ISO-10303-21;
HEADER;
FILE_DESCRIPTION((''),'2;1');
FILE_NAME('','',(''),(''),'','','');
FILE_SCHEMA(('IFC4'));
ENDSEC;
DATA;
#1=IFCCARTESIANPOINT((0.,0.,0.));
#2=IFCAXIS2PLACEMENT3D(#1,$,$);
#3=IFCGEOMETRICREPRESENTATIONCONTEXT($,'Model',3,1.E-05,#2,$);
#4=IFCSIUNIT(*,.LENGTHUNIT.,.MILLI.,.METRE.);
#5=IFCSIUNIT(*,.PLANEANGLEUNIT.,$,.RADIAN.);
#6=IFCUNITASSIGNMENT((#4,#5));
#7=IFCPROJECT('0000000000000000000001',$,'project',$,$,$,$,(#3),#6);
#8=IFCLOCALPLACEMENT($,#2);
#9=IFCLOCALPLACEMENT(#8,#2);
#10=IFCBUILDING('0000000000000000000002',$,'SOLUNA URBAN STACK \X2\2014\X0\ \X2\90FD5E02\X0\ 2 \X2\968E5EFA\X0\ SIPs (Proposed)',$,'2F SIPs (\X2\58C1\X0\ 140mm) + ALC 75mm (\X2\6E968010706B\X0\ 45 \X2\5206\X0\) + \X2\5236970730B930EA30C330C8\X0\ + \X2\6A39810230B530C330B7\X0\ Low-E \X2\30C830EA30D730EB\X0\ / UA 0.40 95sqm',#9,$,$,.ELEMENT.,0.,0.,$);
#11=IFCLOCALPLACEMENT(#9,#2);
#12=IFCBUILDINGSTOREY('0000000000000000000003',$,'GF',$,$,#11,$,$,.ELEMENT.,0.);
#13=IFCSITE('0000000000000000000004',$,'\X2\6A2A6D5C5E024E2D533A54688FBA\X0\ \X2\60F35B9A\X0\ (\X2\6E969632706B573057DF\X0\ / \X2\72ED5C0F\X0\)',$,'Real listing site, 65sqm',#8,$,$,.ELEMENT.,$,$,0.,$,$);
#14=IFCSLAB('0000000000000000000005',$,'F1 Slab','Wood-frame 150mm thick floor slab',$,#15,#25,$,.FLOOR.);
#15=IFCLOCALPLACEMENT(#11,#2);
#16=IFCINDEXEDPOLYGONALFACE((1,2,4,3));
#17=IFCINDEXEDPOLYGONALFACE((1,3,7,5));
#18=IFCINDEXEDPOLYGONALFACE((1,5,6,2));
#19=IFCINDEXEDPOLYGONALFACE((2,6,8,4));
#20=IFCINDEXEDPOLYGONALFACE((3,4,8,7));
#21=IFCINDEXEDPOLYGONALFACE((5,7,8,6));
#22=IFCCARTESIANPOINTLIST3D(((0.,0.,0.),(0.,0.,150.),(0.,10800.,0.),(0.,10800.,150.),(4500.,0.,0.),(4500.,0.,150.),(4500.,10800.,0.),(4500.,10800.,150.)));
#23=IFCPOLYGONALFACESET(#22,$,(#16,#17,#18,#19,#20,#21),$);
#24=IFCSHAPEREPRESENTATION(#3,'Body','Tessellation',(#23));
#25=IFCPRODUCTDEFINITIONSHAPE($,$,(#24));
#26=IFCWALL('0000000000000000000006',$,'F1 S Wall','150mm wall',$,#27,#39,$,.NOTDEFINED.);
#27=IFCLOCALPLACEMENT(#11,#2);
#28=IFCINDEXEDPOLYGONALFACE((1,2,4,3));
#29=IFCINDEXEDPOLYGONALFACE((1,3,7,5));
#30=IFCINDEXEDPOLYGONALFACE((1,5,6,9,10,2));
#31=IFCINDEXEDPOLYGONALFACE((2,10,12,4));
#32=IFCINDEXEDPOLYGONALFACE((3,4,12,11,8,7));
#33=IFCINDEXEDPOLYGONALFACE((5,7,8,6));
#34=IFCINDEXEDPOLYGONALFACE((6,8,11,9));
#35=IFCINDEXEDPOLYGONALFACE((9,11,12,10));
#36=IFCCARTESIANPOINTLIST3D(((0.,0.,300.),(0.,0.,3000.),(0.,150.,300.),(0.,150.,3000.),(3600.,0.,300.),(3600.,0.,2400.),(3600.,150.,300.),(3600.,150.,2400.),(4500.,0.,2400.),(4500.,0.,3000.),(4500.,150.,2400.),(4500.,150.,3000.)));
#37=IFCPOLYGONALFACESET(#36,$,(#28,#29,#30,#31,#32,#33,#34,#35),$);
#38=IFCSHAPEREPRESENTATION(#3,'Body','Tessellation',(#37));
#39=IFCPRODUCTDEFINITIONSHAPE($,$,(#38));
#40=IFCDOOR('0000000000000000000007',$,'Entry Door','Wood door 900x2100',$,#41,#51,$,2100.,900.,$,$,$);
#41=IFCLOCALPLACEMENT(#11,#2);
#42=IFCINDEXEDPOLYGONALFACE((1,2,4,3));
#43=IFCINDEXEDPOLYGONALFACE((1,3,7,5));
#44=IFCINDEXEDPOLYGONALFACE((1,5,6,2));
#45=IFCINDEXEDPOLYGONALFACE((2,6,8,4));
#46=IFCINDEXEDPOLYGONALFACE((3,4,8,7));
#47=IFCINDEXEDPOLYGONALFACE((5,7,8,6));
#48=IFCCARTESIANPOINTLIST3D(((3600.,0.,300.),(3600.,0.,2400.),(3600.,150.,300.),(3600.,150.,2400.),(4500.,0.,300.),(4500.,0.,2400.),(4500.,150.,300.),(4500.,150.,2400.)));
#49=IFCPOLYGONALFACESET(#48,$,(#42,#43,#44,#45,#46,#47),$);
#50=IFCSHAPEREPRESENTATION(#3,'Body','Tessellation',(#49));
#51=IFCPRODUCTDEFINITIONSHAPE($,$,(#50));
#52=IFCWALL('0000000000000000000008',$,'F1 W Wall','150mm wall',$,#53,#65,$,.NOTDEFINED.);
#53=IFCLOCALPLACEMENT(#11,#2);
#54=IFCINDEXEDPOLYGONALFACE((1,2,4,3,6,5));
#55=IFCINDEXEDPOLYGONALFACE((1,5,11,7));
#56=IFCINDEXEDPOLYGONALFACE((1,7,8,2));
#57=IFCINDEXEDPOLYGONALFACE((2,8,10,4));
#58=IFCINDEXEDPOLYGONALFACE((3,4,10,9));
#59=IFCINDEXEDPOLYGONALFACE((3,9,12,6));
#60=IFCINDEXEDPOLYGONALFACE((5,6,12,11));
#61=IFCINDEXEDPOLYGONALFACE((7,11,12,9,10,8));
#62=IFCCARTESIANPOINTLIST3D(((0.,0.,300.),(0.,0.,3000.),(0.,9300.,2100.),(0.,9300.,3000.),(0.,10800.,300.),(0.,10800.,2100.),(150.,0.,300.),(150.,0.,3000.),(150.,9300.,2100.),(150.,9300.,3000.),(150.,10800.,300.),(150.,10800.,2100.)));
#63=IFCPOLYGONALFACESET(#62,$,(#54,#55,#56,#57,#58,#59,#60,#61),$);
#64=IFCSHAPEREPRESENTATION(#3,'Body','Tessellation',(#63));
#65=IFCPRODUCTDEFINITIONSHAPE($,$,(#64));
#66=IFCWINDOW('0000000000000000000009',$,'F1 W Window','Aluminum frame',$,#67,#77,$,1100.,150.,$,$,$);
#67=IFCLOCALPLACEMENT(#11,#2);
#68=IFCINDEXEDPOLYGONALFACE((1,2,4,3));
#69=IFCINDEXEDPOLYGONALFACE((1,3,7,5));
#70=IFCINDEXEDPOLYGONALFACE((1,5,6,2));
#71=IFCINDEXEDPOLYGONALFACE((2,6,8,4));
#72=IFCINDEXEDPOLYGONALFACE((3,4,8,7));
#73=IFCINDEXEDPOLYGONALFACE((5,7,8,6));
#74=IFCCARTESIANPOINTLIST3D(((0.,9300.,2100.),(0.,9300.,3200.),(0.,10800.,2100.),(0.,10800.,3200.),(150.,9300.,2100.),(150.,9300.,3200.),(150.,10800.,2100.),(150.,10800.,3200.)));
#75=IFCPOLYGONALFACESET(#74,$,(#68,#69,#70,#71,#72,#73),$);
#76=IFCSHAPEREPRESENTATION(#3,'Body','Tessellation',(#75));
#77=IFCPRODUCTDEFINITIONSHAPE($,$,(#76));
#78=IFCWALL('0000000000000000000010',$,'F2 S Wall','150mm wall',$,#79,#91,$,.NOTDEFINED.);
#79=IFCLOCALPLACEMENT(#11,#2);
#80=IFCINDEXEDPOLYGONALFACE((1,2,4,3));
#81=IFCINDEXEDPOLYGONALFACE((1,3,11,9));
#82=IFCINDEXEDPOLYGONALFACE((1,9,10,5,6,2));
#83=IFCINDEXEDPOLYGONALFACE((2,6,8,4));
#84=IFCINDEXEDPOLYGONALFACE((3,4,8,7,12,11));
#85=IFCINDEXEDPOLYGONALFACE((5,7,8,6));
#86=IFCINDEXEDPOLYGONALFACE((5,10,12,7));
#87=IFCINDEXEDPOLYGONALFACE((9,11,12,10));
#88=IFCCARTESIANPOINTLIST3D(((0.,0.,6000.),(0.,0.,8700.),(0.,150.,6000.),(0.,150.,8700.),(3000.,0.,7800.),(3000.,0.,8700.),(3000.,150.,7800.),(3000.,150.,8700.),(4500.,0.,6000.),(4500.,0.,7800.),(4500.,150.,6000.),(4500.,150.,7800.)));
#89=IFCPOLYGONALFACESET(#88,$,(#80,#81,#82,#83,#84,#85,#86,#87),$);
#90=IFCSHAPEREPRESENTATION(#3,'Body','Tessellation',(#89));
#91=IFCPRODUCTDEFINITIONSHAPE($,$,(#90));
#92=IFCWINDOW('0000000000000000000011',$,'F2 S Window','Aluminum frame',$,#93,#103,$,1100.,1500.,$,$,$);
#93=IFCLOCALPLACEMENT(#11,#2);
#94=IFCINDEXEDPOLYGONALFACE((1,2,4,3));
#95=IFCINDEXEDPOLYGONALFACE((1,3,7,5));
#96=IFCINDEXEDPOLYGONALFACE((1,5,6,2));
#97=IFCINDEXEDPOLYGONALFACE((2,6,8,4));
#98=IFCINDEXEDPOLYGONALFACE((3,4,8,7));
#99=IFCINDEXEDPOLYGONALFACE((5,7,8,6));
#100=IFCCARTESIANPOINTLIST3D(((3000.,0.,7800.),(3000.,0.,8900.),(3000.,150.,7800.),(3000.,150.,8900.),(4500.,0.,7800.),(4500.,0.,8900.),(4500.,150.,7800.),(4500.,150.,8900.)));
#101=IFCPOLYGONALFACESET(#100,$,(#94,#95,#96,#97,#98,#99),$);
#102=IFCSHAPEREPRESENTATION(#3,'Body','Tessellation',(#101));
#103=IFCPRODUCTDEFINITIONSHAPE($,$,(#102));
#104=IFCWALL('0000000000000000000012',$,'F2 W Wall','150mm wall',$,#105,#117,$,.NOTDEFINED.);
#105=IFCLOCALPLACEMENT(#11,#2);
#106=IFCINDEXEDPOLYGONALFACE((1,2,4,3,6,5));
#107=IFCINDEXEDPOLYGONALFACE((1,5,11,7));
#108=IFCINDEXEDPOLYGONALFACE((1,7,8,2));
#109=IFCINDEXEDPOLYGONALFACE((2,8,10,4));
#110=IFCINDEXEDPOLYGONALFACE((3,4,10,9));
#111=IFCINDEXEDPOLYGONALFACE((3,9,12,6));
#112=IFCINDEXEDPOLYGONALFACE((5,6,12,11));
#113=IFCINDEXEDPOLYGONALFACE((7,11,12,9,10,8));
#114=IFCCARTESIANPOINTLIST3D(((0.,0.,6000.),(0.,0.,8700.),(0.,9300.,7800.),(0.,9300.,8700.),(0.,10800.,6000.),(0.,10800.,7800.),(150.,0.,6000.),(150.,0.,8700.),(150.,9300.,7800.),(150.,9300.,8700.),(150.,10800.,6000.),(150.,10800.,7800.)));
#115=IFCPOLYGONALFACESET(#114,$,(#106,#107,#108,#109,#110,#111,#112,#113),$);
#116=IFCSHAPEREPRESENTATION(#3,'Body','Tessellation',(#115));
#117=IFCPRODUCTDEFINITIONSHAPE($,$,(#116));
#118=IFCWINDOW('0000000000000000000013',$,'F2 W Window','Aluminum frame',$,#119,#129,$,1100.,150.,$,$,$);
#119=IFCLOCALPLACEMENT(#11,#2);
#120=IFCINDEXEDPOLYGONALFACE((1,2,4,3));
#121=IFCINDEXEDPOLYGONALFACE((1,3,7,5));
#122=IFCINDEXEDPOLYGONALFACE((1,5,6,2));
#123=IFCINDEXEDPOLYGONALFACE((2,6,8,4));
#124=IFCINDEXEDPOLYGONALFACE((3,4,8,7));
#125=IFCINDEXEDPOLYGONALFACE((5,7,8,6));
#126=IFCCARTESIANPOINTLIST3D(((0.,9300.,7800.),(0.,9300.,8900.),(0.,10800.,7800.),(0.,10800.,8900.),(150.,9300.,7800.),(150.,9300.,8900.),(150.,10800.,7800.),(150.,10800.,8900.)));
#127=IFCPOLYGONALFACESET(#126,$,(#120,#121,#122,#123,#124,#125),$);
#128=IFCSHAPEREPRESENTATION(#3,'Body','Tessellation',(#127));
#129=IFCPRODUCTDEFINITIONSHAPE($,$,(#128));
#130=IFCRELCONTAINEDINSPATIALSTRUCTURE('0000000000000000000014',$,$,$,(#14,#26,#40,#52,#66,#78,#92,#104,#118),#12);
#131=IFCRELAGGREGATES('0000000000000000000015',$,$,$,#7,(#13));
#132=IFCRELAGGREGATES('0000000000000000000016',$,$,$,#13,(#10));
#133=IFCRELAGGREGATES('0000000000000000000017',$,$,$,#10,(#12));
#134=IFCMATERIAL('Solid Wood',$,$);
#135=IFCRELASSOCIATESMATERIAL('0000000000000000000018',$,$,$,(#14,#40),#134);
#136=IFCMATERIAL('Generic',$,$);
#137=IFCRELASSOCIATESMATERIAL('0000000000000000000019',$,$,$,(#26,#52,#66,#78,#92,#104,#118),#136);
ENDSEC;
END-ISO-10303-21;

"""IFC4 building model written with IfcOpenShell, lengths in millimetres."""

from ifc_helpers import new_model, si_unit, frame, frame_2d, origin, place, context, project, spatial, rectangle, extrude, material, element, fill, save


model = new_model("IFC4")

# Units and contexts
model_context = context("Model", 3, precision=1e-05, world=origin())
ifc_project = project(units=[si_unit("LENGTHUNIT", "METRE", prefix="MILLI"), si_unit("PLANEANGLEUNIT", "RADIAN")], contexts=[model_context])

# Site, building, storey
site_placement = place(None, origin())
site = spatial("IfcSite", under=ifc_project, at=site_placement, Name="横浜市中区周辺 想定 (準防火地域 / 狭小)", ObjectType="Real listing site, 65sqm", CompositionType="ELEMENT", RefElevation=0.0)
building_placement = place(site_placement, origin())
building = spatial("IfcBuilding", under=site, at=building_placement, Name="SOLUNA URBAN STACK — 都市 2 階建 SIPs (Proposed)", ObjectType="2F SIPs (壁 140mm) + ALC 75mm (準耐火 45 分) + 制震スリット + 樹脂サッシ Low-E トリプル / UA 0.40 95sqm", CompositionType="ELEMENT", ElevationOfRefHeight=0.0, ElevationOfTerrain=0.0)
storey_placement = place(building_placement, origin())
storey = spatial("IfcBuildingStorey", under=building, at=storey_placement, Name="GF", CompositionType="ELEMENT", Elevation=0.0)

# Slab
ifc_material_1 = material(Name="Solid Wood")
slab_1_placement = place(storey_placement, origin())
element("IfcSlab", 1, at=slab_1_placement, inside=storey, material=ifc_material_1, Name="F1 Slab", Description="Wood-frame 150mm thick floor slab", PredefinedType="FLOOR", context=model_context, shape_type="SweptSolid", body=[
    extrude(rectangle(XDim=4500.0, YDim=10800.0, at=frame_2d((2250.0, 5400.0))), origin(), (0.0, 0.0, 1.0), 150.0),
])

# Shared definitions
ifc_material_2 = material(Name="Generic")

# Wall, opening, door
wall_1_placement = place(storey_placement, frame((0.0, 0.0, 150.0)))
wall_1 = element("IfcWall", 2, at=wall_1_placement, inside=storey, material=ifc_material_2, Name="F1 S Wall", Description="150mm wall", PredefinedType="NOTDEFINED", context=model_context, shape_type="SweptSolid", body=[
    extrude(rectangle(XDim=4500.0, YDim=150.0, at=frame_2d((2250.0, 75.0))), frame((0.0, 0.0, 150.0)), (0.0, 0.0, 1.0), 2700.0),
])
opening_1_placement = place(storey_placement, frame((1800.0, 0.0, 150.0)))
opening_1 = element("IfcOpeningElement", 3, at=opening_1_placement, cuts=wall_1, PredefinedType="NOTDEFINED", context=model_context, shape_type="SweptSolid", body=[
    extrude(rectangle(XDim=900.0, YDim=150.0, at=frame_2d((450.0, 75.0))), frame((1800.0, 0.0, 150.0)), (0.0, 0.0, 1.0), 2100.0),
])
door_placement = place(storey_placement, frame((1800.0, 0.0, 150.0)))
door = element("IfcDoor", 4, at=door_placement, inside=storey, material=ifc_material_1, Name="Entry Door", Description="Wood door 900x2100", OverallHeight=2100.0, OverallWidth=900.0, context=model_context, shape_type="SweptSolid", body=[
    extrude(rectangle(XDim=900.0, YDim=150.0, at=frame_2d((450.0, 75.0))), frame((1800.0, 0.0, 150.0)), (0.0, 0.0, 1.0), 2100.0),
])
fill(opening_1, door)

# Walls, openings, windows
wall_2_placement = place(storey_placement, frame((0.0, 0.0, 150.0)))
wall_2 = element("IfcWall", 5, at=wall_2_placement, inside=storey, material=ifc_material_2, Name="F1 W Wall", Description="150mm wall", PredefinedType="NOTDEFINED", context=model_context, shape_type="SweptSolid", body=[
    extrude(rectangle(XDim=150.0, YDim=10800.0, at=frame_2d((75.0, 5400.0))), frame((0.0, 0.0, 150.0)), (0.0, 0.0, 1.0), 2700.0),
])
opening_2_placement = place(storey_placement, frame((0.0, 4650.0, 1050.0)))
opening_2 = element("IfcOpeningElement", 6, at=opening_2_placement, cuts=wall_2, PredefinedType="NOTDEFINED", context=model_context, shape_type="SweptSolid", body=[
    extrude(rectangle(XDim=150.0, YDim=1500.0, at=frame_2d((75.0, 750.0))), frame((0.0, 4650.0, 1050.0)), (0.0, 0.0, 1.0), 1100.0),
])
window_1_placement = place(storey_placement, frame((0.0, 4650.0, 1050.0)))
window_1 = element("IfcWindow", 7, at=window_1_placement, inside=storey, material=ifc_material_2, Name="F1 W Window", Description="Aluminum frame", OverallHeight=1100.0, OverallWidth=150.0, context=model_context, shape_type="SweptSolid", body=[
    extrude(rectangle(XDim=150.0, YDim=1500.0, at=frame_2d((75.0, 750.0))), frame((0.0, 4650.0, 1050.0)), (0.0, 0.0, 1.0), 1100.0),
])
fill(opening_2, window_1)
wall_3_placement = place(storey_placement, frame((0.0, 0.0, 3000.0)))
wall_3 = element("IfcWall", 8, at=wall_3_placement, inside=storey, material=ifc_material_2, Name="F2 S Wall", Description="150mm wall", PredefinedType="NOTDEFINED", context=model_context, shape_type="SweptSolid", body=[
    extrude(rectangle(XDim=4500.0, YDim=150.0, at=frame_2d((2250.0, 75.0))), frame((0.0, 0.0, 3000.0)), (0.0, 0.0, 1.0), 2700.0),
])
opening_3_placement = place(storey_placement, frame((1500.0, 0.0, 3900.0)))
opening_3 = element("IfcOpeningElement", 9, at=opening_3_placement, cuts=wall_3, PredefinedType="NOTDEFINED", context=model_context, shape_type="SweptSolid", body=[
    extrude(rectangle(XDim=1500.0, YDim=150.0, at=frame_2d((750.0, 75.0))), frame((1500.0, 0.0, 3900.0)), (0.0, 0.0, 1.0), 1100.0),
])
window_2_placement = place(storey_placement, frame((1500.0, 0.0, 3900.0)))
window_2 = element("IfcWindow", 10, at=window_2_placement, inside=storey, material=ifc_material_2, Name="F2 S Window", Description="Aluminum frame", OverallHeight=1100.0, OverallWidth=1500.0, context=model_context, shape_type="SweptSolid", body=[
    extrude(rectangle(XDim=1500.0, YDim=150.0, at=frame_2d((750.0, 75.0))), frame((1500.0, 0.0, 3900.0)), (0.0, 0.0, 1.0), 1100.0),
])
fill(opening_3, window_2)
wall_4_placement = place(storey_placement, frame((0.0, 0.0, 3000.0)))
wall_4 = element("IfcWall", 11, at=wall_4_placement, inside=storey, material=ifc_material_2, Name="F2 W Wall", Description="150mm wall", PredefinedType="NOTDEFINED", context=model_context, shape_type="SweptSolid", body=[
    extrude(rectangle(XDim=150.0, YDim=10800.0, at=frame_2d((75.0, 5400.0))), frame((0.0, 0.0, 3000.0)), (0.0, 0.0, 1.0), 2700.0),
])
opening_4_placement = place(storey_placement, frame((0.0, 4650.0, 3900.0)))
opening_4 = element("IfcOpeningElement", 12, at=opening_4_placement, cuts=wall_4, PredefinedType="NOTDEFINED", context=model_context, shape_type="SweptSolid", body=[
    extrude(rectangle(XDim=150.0, YDim=1500.0, at=frame_2d((75.0, 750.0))), frame((0.0, 4650.0, 3900.0)), (0.0, 0.0, 1.0), 1100.0),
])
window_3_placement = place(storey_placement, frame((0.0, 4650.0, 3900.0)))
window_3 = element("IfcWindow", 13, at=window_3_placement, inside=storey, material=ifc_material_2, Name="F2 W Window", Description="Aluminum frame", OverallHeight=1100.0, OverallWidth=150.0, context=model_context, shape_type="SweptSolid", body=[
    extrude(rectangle(XDim=150.0, YDim=1500.0, at=frame_2d((75.0, 750.0))), frame((0.0, 4650.0, 3900.0)), (0.0, 0.0, 1.0), 1100.0),
])
fill(opening_4, window_3)

save(model, "model.ifc")
